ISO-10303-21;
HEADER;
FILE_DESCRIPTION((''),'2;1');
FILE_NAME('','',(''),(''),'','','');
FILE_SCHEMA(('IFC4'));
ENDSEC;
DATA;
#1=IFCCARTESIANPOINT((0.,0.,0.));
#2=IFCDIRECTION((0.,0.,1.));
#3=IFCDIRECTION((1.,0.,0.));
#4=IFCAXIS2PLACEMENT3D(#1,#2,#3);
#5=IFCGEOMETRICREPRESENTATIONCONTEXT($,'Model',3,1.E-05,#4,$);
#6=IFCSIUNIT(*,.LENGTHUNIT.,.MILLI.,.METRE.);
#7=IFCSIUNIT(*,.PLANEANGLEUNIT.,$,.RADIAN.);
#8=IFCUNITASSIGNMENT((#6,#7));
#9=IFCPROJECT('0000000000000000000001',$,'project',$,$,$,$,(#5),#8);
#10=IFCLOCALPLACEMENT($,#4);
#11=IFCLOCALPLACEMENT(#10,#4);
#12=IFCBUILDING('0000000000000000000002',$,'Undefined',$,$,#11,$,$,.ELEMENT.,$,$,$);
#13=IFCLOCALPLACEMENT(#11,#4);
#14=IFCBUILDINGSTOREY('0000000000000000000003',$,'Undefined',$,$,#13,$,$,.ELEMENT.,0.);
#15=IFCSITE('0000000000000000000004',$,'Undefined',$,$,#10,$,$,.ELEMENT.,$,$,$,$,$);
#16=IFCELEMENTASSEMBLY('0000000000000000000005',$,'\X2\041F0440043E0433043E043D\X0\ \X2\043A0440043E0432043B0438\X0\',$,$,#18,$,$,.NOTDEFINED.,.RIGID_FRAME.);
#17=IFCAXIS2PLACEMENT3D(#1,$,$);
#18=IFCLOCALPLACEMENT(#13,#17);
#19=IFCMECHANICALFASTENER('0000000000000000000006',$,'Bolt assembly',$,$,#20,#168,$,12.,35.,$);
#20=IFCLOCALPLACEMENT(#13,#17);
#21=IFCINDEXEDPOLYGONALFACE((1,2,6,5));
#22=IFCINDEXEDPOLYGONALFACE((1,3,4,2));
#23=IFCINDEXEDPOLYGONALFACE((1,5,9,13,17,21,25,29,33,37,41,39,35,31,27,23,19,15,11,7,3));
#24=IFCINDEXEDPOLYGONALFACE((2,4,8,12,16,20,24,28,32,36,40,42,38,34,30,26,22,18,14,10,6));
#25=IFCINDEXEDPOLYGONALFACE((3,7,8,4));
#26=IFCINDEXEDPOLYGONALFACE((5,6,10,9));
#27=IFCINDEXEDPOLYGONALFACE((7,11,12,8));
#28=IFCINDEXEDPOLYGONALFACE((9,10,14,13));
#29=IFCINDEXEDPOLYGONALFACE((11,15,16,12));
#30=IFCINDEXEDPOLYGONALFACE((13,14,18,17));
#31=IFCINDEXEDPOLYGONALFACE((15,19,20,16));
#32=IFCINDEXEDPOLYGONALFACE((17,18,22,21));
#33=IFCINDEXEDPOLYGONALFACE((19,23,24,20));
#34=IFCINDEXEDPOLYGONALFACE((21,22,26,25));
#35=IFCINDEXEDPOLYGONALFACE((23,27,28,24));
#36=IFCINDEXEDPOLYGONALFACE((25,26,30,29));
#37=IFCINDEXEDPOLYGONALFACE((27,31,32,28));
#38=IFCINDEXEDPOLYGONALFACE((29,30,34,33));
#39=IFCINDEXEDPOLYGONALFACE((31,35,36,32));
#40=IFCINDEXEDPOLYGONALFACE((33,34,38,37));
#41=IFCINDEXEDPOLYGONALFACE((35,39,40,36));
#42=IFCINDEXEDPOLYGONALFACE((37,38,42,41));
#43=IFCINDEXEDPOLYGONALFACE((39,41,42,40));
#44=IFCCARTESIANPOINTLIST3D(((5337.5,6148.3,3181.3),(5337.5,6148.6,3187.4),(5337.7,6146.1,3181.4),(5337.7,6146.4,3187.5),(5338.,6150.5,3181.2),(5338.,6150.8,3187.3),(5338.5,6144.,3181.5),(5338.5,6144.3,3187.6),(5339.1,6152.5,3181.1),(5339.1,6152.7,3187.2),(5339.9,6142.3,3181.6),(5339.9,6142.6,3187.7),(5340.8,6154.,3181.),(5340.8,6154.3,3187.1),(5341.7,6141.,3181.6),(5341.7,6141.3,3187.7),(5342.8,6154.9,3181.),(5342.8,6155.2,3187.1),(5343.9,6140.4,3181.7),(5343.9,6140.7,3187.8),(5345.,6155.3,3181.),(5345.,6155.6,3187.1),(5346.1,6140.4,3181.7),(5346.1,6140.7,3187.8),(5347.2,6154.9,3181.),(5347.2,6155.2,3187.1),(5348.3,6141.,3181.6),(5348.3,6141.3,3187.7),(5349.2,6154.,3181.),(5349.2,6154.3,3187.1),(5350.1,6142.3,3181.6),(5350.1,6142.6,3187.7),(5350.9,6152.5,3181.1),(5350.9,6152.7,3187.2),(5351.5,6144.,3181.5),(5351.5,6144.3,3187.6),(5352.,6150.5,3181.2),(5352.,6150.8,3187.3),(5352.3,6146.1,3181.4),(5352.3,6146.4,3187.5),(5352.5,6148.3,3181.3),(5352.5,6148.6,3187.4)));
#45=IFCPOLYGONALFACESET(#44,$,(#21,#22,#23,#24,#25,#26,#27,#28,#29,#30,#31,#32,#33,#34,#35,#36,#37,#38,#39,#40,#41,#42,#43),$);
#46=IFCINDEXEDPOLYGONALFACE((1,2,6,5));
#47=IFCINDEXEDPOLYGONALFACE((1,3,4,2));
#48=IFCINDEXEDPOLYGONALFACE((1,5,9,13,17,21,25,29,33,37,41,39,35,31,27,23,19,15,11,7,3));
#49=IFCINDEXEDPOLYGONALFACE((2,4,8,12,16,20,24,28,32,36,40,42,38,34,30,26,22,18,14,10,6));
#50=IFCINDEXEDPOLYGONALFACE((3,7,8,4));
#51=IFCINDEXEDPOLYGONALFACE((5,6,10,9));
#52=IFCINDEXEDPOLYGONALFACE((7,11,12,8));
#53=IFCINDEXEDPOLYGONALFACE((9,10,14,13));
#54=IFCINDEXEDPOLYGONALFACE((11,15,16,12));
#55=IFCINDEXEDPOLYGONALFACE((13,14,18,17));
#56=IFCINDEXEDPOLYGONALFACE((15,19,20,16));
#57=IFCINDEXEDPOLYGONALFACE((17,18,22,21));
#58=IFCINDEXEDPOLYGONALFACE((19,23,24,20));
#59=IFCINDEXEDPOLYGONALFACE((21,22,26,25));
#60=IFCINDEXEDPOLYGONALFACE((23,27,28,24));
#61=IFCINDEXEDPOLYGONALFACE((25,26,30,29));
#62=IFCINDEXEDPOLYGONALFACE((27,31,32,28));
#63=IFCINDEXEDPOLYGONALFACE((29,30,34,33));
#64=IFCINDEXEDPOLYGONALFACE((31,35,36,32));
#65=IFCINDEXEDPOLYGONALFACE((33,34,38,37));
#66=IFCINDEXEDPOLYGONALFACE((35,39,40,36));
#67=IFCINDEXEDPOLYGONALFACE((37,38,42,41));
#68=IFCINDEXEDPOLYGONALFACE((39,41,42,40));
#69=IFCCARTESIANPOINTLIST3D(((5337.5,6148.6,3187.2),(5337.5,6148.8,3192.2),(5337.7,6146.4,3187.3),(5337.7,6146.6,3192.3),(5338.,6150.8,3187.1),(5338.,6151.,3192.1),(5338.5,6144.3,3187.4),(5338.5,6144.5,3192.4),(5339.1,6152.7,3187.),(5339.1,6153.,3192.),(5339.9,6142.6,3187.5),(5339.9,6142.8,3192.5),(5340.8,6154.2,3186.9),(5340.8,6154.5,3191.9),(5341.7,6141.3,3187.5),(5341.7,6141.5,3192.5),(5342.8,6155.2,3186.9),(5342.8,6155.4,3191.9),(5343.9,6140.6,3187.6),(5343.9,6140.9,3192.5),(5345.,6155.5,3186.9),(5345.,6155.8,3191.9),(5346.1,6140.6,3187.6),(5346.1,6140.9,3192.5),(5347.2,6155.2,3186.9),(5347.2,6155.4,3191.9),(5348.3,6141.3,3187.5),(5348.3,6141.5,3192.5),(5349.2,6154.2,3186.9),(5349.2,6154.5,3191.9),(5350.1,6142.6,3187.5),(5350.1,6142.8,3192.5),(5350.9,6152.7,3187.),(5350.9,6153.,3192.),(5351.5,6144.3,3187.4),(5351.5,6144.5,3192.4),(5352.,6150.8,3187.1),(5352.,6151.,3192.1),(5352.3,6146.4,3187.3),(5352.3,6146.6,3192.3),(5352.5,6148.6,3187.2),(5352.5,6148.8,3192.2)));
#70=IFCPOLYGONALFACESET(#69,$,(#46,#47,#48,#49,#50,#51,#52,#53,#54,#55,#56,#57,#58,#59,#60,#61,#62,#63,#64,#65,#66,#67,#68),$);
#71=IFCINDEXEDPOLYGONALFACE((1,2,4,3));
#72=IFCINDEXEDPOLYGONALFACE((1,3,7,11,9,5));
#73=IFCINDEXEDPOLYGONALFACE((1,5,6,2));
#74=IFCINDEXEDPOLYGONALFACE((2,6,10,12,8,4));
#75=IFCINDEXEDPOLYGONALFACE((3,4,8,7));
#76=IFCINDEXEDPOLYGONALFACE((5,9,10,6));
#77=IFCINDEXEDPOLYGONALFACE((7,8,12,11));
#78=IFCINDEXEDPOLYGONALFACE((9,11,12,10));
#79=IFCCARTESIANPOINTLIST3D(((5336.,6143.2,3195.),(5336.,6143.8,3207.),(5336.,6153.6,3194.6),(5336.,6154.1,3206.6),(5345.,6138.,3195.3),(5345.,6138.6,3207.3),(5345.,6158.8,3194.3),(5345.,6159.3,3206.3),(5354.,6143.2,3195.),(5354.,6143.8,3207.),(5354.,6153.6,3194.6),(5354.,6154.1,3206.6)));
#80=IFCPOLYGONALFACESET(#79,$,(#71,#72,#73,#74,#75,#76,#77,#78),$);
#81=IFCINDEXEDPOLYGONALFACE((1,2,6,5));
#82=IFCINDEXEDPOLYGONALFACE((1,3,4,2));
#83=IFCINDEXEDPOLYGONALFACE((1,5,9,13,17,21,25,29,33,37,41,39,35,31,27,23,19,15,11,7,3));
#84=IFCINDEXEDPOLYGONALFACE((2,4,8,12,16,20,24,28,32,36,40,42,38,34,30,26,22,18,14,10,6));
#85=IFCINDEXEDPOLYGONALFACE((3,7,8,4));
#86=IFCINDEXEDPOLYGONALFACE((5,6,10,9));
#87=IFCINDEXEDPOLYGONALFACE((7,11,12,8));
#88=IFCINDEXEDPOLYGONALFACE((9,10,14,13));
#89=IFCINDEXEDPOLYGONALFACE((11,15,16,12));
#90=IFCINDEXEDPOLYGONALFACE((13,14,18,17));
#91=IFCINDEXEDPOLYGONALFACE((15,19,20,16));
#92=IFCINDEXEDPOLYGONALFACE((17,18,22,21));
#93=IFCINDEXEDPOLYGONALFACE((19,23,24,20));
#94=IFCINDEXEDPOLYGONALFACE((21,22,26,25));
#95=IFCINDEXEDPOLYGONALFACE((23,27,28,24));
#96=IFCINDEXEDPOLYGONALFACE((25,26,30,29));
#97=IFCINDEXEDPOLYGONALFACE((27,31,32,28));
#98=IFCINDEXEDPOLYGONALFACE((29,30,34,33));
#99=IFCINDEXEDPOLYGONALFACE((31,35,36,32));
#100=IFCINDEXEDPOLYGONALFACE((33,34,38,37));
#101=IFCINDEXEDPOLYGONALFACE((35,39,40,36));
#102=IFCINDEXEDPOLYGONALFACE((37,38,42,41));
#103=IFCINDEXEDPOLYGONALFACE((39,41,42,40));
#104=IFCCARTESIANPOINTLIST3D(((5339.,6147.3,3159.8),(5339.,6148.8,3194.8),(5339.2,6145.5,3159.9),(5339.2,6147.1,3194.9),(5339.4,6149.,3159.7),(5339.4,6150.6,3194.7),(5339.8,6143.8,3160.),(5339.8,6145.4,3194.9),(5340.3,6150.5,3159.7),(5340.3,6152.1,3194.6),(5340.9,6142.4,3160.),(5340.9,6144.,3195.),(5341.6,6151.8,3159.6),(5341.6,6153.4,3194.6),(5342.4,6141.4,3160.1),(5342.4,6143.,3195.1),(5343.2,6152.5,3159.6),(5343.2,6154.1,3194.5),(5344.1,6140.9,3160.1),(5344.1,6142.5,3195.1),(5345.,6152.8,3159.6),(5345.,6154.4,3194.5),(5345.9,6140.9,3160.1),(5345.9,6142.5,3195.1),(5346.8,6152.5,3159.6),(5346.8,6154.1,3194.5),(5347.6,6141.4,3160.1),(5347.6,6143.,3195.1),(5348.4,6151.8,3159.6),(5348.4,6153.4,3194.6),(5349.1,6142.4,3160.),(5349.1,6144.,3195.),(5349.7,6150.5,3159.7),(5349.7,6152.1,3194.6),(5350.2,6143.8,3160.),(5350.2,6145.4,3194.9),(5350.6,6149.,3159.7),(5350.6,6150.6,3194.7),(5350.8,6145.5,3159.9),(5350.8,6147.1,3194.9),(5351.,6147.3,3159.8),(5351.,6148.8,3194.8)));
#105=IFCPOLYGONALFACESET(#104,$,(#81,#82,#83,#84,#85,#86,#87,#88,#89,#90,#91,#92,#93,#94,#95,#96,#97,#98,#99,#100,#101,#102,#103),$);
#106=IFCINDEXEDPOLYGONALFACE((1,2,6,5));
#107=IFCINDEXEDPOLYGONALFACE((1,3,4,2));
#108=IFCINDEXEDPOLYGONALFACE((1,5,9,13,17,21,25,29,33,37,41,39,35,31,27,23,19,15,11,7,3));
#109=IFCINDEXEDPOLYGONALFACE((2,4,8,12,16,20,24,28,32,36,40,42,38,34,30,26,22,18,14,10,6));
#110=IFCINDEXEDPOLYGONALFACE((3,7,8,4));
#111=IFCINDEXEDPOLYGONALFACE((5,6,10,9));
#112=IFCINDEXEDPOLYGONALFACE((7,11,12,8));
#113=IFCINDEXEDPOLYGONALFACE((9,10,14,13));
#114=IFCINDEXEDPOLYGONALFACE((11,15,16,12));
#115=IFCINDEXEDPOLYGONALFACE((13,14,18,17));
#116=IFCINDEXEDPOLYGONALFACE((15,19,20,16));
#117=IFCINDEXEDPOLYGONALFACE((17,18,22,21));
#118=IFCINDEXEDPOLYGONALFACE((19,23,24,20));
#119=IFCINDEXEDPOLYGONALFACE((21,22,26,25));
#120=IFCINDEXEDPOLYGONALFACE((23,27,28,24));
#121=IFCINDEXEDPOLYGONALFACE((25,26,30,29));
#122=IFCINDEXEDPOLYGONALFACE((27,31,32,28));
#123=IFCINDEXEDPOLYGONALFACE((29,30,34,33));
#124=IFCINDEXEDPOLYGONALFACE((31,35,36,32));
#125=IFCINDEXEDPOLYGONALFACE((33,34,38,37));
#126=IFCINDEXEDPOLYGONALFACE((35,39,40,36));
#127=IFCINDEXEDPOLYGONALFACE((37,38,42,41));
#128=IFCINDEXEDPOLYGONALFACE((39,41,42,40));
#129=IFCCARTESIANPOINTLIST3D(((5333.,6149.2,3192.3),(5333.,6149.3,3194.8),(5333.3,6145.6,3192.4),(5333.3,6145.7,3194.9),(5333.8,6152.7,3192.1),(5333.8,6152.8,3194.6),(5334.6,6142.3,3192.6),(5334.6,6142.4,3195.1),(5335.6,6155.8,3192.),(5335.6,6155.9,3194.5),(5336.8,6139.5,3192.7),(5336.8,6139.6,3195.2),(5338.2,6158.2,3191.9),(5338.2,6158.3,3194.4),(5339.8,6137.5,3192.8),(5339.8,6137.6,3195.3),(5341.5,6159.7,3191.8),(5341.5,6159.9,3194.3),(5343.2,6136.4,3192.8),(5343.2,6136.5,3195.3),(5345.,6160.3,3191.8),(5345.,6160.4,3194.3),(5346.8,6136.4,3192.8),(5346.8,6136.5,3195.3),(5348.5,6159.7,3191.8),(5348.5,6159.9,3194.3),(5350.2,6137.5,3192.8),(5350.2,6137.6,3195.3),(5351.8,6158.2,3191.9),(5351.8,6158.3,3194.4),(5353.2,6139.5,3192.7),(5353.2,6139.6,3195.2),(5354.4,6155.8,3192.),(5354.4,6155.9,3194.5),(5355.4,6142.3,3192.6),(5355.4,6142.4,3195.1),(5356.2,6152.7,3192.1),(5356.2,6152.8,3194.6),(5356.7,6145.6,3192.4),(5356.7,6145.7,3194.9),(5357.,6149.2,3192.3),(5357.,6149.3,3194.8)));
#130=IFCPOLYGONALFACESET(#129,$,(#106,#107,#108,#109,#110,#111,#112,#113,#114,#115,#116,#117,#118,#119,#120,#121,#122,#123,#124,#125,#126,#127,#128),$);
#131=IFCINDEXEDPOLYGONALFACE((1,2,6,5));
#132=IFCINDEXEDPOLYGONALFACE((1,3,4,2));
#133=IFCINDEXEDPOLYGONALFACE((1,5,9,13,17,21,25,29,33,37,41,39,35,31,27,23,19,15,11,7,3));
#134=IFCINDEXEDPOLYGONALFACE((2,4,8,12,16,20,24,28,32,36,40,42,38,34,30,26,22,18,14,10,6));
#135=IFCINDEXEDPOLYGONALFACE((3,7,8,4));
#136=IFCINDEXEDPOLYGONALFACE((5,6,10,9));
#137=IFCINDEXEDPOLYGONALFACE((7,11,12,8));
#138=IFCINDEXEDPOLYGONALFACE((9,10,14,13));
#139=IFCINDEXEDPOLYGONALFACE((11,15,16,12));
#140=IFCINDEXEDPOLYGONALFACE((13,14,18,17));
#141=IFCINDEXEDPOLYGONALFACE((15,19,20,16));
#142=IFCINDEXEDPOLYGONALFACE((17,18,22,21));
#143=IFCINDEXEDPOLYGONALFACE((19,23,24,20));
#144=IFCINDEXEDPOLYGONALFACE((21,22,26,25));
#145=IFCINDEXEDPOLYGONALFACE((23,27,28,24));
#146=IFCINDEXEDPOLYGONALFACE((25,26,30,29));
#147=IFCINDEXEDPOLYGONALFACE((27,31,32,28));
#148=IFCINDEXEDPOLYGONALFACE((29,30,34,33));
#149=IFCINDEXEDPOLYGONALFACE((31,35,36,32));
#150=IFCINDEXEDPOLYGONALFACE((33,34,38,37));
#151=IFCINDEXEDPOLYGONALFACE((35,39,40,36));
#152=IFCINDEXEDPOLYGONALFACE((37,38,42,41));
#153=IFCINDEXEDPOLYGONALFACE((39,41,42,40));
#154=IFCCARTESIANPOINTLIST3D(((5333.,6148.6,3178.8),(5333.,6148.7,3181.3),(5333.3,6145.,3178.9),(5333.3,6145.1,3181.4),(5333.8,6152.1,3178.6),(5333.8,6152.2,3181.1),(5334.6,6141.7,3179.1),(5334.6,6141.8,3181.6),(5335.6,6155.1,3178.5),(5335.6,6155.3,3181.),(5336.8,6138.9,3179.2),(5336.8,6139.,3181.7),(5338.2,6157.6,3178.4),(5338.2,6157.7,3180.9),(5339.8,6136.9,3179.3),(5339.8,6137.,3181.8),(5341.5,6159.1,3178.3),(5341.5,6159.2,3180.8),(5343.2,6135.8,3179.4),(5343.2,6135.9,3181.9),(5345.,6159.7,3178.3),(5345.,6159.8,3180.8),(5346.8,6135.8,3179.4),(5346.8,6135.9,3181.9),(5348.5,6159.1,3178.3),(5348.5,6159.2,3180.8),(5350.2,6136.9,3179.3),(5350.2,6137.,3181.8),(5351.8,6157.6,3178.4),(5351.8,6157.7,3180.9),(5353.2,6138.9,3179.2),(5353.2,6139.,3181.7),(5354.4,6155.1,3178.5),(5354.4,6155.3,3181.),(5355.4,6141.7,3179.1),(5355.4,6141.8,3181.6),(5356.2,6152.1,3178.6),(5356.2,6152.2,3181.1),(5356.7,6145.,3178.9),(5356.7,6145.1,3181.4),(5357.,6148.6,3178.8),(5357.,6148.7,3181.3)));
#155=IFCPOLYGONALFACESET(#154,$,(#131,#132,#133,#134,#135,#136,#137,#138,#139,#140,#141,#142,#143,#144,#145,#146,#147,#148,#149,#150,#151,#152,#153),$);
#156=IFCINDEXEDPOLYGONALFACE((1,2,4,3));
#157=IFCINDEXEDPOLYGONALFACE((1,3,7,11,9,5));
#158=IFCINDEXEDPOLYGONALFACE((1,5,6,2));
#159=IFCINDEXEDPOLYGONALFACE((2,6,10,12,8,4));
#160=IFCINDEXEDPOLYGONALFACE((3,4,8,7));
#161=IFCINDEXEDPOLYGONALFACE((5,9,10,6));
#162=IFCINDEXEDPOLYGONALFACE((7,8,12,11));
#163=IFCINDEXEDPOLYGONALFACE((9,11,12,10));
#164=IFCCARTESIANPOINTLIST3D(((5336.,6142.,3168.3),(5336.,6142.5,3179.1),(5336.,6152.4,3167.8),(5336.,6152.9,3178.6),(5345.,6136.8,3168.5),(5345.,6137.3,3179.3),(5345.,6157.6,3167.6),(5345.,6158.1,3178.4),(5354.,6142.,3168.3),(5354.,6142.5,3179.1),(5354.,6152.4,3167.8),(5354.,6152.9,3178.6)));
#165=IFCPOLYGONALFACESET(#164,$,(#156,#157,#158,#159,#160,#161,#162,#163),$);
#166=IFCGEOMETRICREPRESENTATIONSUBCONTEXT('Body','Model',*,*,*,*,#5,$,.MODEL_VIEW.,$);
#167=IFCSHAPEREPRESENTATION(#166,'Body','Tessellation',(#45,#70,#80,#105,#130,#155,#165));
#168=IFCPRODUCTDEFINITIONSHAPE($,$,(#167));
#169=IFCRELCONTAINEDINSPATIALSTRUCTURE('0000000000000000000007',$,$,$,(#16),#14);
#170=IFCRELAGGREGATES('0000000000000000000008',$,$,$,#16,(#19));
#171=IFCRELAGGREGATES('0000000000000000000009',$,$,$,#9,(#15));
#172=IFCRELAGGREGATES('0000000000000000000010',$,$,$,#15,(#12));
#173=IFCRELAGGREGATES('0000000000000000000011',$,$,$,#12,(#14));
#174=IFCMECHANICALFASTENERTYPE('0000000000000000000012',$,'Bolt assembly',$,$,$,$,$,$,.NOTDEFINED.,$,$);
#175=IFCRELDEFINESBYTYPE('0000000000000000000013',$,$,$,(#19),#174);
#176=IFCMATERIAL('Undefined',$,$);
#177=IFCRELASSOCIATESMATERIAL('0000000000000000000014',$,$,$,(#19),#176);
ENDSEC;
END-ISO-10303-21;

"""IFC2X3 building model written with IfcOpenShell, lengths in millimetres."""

from ifc_helpers import new_model, si_unit, frame, origin_with_axes, origin_2d_with_axis, place, context, subcontext, project, spatial, polyline, circle, outline, extrude, source, transform, mapped, material, type_object, element, aggregate, save


model = new_model("IFC2X3")

# Units and contexts
model_context = context("Model", 3, precision=1e-05, world=origin_with_axes())
body_context = subcontext(model_context, "Body", "Model", "MODEL_VIEW")
ifc_project = project(units=[si_unit("LENGTHUNIT", "METRE", prefix="MILLI"), si_unit("PLANEANGLEUNIT", "RADIAN")], contexts=[model_context])

# Site, building, storey
site_placement = place(None, origin_with_axes())
site = spatial("IfcSite", under=ifc_project, at=site_placement, Name="Undefined", CompositionType="ELEMENT")
building_placement = place(site_placement, origin_with_axes())
building = spatial("IfcBuilding", under=site, at=building_placement, Name="Undefined", CompositionType="ELEMENT")
storey_placement = place(building_placement, origin_with_axes())
storey = spatial("IfcBuildingStorey", under=building, at=storey_placement, Name="Undefined", CompositionType="ELEMENT", Elevation=0.0)

# Element assembly
assembly_1_placement = place(storey_placement, origin_with_axes())
assembly_1 = element("IfcElementAssembly", 1, at=assembly_1_placement, inside=storey, Name="Прогон кровли", AssemblyPlace="NOTDEFINED", PredefinedType="RIGID_FRAME")

# Mechanical fastener
ifc_material_1 = material(Name="Undefined")
mechanical_fastener_type = type_object("IfcMechanicalFastenerType", Name="Bolt assembly")
shared_shape_1 = source(origin_with_axes(), body_context, "Body", "SweptSolid", [
    extrude(circle(Radius=7.5, at=origin_2d_with_axis()), frame((0.0, -0.1, 0.0), z_axis=(0.0, 1.0, 0.0), x_axis=(1.0, 0.0, 0.0)), (0.0, 0.0, 1.0), 6.1),
    extrude(circle(Radius=7.5, at=origin_2d_with_axis()), frame((0.0, -4.9, 0.0), z_axis=(0.0, 1.0, 0.0), x_axis=(1.0, 0.0, 0.0)), (0.0, 0.0, 1.0), 5.0),
    extrude(outline(polyline([(10.4, 0.0), (5.2, 9.0), (-5.2, 9.0), (-10.4, 0.0), (-5.2, -9.0), (5.2, -9.0), (10.4, 0.0)])), frame((0.0, -19.5, 0.0), z_axis=(0.0, 1.0, 0.0), x_axis=(1.0, 0.0, 0.0)), (0.0, 0.0, 1.0), 12.0),
    extrude(circle(Radius=6.0, at=origin_2d_with_axis()), frame((0.0, -7.5, 0.0), z_axis=(0.0, 1.0, 0.0), x_axis=(1.0, 0.0, 0.0)), (0.0, 0.0, 1.0), 35.0),
    extrude(circle(Radius=12.0, at=origin_2d_with_axis()), frame((0.0, -7.5, 0.0), z_axis=(0.0, 1.0, 0.0), x_axis=(1.0, 0.0, 0.0)), (0.0, 0.0, 1.0), 2.5),
    extrude(circle(Radius=12.0, at=origin_2d_with_axis()), frame((0.0, 6.0, 0.0), z_axis=(0.0, 1.0, 0.0), x_axis=(1.0, 0.0, 0.0)), (0.0, 0.0, 1.0), 2.5),
    extrude(outline(polyline([(10.4, 0.0), (5.2, 9.0), (-5.2, 9.0), (-10.4, 0.0), (-5.2, -9.0), (5.2, -9.0), (10.4, 0.0)])), frame((0.0, 8.5, 0.0), z_axis=(0.0, 1.0, 0.0), x_axis=(1.0, 0.0, 0.0)), (0.0, 0.0, 1.0), 10.8),
])
mechanical_fastener_1_placement = place(assembly_1_placement, frame((5345.0, 6148.1, 3187.3), z_axis=(-1.0, 0.0, 0.0), x_axis=(0.0, 0.998969, -0.045408)))
mechanical_fastener_1 = element("IfcMechanicalFastener", 2, at=mechanical_fastener_1_placement, type_object=mechanical_fastener_type, material=ifc_material_1, Name="Bolt assembly", NominalDiameter=12.0, NominalLength=35.0, context=body_context, shape_type="MappedRepresentation", body=[
    mapped(shared_shape_1, transform((0.0, 0.0, 0.0))),
])
aggregate(assembly_1, [mechanical_fastener_1])

save(model, "model.ifc")
